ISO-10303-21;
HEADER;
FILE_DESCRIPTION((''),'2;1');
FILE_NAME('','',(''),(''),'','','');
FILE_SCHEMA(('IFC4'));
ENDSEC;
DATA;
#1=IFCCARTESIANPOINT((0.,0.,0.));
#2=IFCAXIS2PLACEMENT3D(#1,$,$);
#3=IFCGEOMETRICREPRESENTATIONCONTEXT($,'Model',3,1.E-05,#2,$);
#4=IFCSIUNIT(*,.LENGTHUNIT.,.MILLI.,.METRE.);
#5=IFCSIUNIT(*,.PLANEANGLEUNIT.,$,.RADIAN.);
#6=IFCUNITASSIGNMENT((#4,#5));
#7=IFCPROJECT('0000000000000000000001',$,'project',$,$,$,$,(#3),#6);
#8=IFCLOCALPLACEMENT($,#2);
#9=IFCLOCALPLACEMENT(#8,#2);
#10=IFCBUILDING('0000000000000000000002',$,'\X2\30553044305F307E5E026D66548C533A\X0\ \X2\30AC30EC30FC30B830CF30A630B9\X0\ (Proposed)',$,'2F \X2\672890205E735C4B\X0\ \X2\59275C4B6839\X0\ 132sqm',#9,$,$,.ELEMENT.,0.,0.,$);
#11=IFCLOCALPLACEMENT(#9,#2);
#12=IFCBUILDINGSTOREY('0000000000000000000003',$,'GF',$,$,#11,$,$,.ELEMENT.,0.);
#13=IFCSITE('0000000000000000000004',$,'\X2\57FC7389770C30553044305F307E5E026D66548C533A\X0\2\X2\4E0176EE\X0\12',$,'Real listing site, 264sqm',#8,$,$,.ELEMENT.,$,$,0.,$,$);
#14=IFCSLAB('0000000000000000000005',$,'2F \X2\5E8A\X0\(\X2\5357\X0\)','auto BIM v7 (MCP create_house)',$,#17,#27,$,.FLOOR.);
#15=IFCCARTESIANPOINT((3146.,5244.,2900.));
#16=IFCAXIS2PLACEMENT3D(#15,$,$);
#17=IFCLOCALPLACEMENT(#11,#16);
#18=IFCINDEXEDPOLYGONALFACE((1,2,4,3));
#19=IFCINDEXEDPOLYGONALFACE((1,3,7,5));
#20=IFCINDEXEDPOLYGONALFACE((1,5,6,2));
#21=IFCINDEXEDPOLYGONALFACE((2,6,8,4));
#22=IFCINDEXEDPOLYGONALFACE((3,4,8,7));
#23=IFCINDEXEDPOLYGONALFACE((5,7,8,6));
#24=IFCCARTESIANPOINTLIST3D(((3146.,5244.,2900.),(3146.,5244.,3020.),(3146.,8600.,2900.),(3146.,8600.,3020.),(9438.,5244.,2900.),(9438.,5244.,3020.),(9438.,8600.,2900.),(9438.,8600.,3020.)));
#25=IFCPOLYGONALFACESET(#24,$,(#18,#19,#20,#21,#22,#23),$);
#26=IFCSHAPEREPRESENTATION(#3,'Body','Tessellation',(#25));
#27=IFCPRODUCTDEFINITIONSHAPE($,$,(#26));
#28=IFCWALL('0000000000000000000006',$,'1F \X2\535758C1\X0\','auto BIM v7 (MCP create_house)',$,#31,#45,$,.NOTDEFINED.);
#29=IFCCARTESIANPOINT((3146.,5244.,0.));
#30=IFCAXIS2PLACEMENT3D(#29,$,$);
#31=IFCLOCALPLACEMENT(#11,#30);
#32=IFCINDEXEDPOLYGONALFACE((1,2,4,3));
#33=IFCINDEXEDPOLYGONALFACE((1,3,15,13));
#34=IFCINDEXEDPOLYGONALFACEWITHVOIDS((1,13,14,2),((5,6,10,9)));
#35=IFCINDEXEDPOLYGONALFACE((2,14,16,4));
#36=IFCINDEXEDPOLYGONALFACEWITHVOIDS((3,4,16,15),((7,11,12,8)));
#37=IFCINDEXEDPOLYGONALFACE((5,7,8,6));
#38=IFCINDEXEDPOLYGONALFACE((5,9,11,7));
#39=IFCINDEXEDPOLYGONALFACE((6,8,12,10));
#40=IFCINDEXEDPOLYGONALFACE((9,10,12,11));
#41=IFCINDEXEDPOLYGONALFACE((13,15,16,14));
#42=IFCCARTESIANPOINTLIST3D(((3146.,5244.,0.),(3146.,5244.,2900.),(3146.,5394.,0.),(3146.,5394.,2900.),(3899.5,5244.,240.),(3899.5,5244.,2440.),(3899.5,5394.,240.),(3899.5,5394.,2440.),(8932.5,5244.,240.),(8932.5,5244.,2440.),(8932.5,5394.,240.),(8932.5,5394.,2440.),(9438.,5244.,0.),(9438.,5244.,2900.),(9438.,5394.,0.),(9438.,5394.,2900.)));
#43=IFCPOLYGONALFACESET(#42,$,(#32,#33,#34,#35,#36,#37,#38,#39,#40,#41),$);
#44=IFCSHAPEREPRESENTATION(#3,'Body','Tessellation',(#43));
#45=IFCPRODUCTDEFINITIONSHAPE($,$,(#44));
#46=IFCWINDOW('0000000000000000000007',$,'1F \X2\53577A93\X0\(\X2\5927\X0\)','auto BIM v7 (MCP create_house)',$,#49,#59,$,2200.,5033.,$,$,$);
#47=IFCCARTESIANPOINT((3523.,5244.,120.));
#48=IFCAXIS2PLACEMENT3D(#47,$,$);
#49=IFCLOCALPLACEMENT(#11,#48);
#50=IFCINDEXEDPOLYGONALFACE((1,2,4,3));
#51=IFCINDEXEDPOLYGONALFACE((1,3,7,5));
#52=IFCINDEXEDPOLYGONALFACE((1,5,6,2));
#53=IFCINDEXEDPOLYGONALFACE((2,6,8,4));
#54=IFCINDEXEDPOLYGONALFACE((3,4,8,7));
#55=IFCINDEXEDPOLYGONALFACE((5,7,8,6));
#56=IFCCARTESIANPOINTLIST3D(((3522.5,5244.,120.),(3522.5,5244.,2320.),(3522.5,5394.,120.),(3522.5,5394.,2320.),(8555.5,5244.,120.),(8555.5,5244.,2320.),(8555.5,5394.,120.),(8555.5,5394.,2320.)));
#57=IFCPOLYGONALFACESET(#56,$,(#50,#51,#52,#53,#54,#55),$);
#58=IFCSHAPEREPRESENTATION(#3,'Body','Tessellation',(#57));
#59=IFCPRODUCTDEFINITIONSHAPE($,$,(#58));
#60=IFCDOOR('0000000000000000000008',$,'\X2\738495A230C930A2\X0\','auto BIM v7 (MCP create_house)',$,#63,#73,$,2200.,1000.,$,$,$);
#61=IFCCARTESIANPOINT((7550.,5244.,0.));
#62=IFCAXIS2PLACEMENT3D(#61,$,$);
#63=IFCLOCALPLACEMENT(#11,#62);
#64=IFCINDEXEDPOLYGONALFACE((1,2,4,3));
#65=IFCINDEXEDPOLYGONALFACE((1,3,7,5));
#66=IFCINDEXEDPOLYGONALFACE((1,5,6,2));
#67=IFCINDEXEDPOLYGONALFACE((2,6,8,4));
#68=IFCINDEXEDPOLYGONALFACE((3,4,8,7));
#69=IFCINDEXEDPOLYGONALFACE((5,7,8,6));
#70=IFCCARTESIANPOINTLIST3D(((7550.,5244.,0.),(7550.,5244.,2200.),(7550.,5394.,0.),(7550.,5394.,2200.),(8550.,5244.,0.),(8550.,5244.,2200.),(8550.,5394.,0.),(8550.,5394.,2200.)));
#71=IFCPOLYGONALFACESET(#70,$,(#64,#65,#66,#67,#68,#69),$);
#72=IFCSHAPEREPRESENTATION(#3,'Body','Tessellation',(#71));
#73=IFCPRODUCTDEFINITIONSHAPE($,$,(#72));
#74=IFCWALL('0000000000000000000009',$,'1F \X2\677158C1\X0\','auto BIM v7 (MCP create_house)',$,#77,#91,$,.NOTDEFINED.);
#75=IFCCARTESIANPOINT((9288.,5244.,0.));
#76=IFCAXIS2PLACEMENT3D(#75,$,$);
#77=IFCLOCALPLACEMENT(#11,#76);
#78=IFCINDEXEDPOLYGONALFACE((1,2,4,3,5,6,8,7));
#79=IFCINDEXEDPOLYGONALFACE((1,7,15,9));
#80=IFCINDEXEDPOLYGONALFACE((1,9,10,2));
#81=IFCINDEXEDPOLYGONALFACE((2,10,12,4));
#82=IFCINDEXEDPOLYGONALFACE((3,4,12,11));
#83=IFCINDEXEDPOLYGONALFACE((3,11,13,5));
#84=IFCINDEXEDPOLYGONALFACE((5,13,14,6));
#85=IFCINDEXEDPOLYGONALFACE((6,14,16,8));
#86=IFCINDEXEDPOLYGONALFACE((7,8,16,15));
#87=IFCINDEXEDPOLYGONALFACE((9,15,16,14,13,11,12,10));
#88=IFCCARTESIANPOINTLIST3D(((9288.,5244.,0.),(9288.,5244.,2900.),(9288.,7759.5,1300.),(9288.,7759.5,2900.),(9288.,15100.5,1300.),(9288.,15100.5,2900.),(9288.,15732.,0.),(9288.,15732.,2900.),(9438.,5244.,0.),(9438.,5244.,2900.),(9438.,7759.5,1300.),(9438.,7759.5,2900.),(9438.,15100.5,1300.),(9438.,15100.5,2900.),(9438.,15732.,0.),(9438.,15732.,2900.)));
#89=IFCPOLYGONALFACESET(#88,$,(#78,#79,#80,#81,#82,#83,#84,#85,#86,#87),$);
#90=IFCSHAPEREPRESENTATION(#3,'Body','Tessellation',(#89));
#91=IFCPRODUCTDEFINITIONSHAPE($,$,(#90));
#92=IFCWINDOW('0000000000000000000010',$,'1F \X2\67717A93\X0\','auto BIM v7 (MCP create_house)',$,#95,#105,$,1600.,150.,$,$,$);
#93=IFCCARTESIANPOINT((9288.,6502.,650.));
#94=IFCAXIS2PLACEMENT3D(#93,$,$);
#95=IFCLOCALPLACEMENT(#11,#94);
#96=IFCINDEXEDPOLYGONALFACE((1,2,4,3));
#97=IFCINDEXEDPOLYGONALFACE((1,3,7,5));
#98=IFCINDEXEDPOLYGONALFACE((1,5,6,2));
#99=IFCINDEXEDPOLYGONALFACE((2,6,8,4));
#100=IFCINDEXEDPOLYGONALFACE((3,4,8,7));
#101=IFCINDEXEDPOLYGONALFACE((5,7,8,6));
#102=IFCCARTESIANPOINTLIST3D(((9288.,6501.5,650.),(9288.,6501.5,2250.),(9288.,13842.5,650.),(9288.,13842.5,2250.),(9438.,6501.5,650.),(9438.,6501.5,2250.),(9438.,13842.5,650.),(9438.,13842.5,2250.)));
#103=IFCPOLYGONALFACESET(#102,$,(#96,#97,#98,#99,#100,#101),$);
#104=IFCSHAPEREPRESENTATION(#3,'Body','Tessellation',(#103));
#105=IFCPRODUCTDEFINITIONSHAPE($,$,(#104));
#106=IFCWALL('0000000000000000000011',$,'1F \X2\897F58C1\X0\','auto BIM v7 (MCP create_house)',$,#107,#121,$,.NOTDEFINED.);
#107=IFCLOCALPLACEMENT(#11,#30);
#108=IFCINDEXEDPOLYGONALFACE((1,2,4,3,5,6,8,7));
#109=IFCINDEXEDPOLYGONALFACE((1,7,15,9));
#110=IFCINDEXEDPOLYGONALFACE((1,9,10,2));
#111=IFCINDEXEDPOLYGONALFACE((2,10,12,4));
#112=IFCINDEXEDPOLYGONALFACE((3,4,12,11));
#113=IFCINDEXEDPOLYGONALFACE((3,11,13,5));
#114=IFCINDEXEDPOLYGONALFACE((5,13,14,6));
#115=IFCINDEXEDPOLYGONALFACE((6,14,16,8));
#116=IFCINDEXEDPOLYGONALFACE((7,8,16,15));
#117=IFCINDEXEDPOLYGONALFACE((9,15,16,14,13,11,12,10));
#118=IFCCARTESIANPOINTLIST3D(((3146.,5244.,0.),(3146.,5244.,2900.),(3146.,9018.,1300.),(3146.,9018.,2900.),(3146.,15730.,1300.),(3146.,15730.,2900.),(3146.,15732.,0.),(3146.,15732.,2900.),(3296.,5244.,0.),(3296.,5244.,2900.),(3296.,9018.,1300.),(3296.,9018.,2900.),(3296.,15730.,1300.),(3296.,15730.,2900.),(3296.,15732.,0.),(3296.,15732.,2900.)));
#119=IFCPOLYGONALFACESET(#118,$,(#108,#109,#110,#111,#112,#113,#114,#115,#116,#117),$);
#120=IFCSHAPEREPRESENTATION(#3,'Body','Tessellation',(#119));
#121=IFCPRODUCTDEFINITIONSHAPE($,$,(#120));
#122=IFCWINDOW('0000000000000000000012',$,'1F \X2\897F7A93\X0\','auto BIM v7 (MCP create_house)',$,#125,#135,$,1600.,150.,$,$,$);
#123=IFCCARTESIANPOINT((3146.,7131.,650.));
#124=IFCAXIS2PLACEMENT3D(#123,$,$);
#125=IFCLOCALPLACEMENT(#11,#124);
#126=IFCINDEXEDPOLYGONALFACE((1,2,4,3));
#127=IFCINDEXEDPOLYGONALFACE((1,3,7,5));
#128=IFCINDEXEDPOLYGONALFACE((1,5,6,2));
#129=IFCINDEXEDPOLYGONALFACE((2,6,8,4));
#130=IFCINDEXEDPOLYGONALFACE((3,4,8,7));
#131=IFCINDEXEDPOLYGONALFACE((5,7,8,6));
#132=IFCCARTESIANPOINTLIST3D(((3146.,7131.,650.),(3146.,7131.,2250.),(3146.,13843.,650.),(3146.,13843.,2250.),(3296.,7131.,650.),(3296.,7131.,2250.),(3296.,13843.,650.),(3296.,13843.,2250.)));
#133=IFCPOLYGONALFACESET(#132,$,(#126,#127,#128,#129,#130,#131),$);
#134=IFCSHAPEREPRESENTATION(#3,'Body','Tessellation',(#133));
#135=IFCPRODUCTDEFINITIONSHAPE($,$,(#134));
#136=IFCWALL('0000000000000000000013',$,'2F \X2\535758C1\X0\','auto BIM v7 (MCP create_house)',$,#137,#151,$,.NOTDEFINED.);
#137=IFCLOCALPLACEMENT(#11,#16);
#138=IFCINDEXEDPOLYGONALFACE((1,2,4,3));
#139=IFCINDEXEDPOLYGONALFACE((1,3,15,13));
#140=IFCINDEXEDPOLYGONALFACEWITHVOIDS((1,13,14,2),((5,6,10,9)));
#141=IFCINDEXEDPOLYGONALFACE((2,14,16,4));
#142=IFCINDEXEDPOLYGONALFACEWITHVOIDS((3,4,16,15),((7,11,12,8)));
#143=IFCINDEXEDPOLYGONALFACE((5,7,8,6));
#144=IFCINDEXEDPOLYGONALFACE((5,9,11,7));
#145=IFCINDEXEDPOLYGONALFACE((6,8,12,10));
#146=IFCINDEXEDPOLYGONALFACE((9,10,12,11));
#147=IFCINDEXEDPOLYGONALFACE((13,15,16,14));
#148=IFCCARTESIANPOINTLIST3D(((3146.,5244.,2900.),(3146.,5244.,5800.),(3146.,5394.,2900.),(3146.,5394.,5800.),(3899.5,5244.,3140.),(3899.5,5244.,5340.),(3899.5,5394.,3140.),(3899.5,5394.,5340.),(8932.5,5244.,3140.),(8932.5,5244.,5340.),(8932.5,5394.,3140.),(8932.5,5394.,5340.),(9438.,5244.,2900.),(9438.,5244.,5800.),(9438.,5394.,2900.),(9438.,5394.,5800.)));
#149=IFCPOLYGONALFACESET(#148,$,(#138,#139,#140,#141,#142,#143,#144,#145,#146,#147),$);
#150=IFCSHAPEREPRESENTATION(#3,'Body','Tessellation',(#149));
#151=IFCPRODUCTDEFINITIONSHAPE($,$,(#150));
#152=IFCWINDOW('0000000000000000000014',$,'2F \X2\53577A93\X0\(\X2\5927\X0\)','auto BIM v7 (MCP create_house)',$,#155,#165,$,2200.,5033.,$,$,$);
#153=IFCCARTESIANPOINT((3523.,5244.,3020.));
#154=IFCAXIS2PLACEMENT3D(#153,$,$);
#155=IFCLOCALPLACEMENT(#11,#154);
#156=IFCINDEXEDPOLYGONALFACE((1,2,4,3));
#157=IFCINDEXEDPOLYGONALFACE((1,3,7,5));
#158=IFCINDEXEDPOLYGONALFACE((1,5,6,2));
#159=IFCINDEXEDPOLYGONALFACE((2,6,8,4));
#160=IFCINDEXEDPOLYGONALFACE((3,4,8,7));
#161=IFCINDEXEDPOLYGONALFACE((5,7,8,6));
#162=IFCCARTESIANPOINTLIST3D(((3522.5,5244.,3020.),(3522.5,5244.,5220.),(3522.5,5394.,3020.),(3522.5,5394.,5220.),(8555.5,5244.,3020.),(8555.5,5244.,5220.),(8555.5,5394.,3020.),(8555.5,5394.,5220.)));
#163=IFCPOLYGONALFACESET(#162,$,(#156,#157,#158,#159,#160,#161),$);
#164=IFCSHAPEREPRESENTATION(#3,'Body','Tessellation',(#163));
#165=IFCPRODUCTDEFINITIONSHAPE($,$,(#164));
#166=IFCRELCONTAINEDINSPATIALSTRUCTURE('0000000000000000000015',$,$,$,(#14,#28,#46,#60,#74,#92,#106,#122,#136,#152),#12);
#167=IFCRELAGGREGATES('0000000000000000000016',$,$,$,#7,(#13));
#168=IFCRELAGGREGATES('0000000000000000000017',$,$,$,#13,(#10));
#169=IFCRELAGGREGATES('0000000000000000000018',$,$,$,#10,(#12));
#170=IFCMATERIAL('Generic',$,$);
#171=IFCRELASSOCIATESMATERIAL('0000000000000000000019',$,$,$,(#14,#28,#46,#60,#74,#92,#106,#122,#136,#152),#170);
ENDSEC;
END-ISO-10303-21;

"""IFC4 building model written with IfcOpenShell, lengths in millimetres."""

from ifc_helpers import new_model, si_unit, frame, frame_2d, origin, place, context, project, spatial, rectangle, extrude, material, element, fill, save


model = new_model("IFC4")

# Units and contexts
model_context = context("Model", 3, precision=1e-05, world=origin())
ifc_project = project(units=[si_unit("LENGTHUNIT", "METRE", prefix="MILLI"), si_unit("PLANEANGLEUNIT", "RADIAN")], contexts=[model_context])

# Site, building, storey
site_placement = place(None, origin())
site = spatial("IfcSite", under=ifc_project, at=site_placement, Name="埼玉県さいたま市浦和区2丁目12", ObjectType="Real listing site, 264sqm", CompositionType="ELEMENT", RefElevation=0.0)
building_placement = place(site_placement, origin())
building = spatial("IfcBuilding", under=site, at=building_placement, Name="さいたま市浦和区 ガレージハウス (Proposed)", ObjectType="2F 木造平屋 大屋根 132sqm", CompositionType="ELEMENT", ElevationOfRefHeight=0.0, ElevationOfTerrain=0.0)
storey_placement = place(building_placement, origin())
storey = spatial("IfcBuildingStorey", under=building, at=storey_placement, Name="GF", CompositionType="ELEMENT", Elevation=0.0)

# Slab
ifc_material = material(Name="Generic")
slab_1_placement = place(storey_placement, frame((3146.0, 5244.0, 2900.0)))
element("IfcSlab", 1, at=slab_1_placement, inside=storey, material=ifc_material, Name="2F 床(南)", Description="auto BIM v7 (MCP create_house)", PredefinedType="FLOOR", context=model_context, shape_type="SweptSolid", body=[
    extrude(rectangle(XDim=6292.0, YDim=3356.0, at=frame_2d((3146.0, 1678.0))), frame((3146.0, 5244.0, 2900.0)), (0.0, 0.0, 1.0), 120.0),
])

# Wall, openings, window, door
wall_1_placement = place(storey_placement, frame((3146.0, 5244.0, 0.0)))
wall_1 = element("IfcWall", 2, at=wall_1_placement, inside=storey, material=ifc_material, Name="1F 南壁", Description="auto BIM v7 (MCP create_house)", PredefinedType="NOTDEFINED", context=model_context, shape_type="SweptSolid", body=[
    extrude(rectangle(XDim=6292.0, YDim=150.0, at=frame_2d((3146.0, 75.0))), frame((3146.0, 5244.0, 0.0)), (0.0, 0.0, 1.0), 2900.0),
])
opening_1_placement = place(storey_placement, frame((3523.0, 5244.0, 120.0)))
opening_1 = element("IfcOpeningElement", 3, at=opening_1_placement, cuts=wall_1, PredefinedType="NOTDEFINED", context=model_context, shape_type="SweptSolid", body=[
    extrude(rectangle(XDim=5033.0, YDim=150.0, at=frame_2d((2516.0, 75.0))), frame((3523.0, 5244.0, 120.0)), (0.0, 0.0, 1.0), 2200.0),
])
opening_2_placement = place(storey_placement, frame((7550.0, 5244.0, 0.0)))
opening_2 = element("IfcOpeningElement", 4, at=opening_2_placement, cuts=wall_1, PredefinedType="NOTDEFINED", context=model_context, shape_type="SweptSolid", body=[
    extrude(rectangle(XDim=1000.0, YDim=150.0, at=frame_2d((500.0, 75.0))), frame((7550.0, 5244.0, 0.0)), (0.0, 0.0, 1.0), 2200.0),
])
window_1_placement = place(storey_placement, frame((3523.0, 5244.0, 120.0)))
window_1 = element("IfcWindow", 5, at=window_1_placement, inside=storey, material=ifc_material, Name="1F 南窓(大)", Description="auto BIM v7 (MCP create_house)", OverallHeight=2200.0, OverallWidth=5033.0, context=model_context, shape_type="SweptSolid", body=[
    extrude(rectangle(XDim=5033.0, YDim=150.0, at=frame_2d((2516.0, 75.0))), frame((3523.0, 5244.0, 120.0)), (0.0, 0.0, 1.0), 2200.0),
])
fill(opening_1, window_1)
door_placement = place(storey_placement, frame((7550.0, 5244.0, 0.0)))
door = element("IfcDoor", 6, at=door_placement, inside=storey, material=ifc_material, Name="玄関ドア", Description="auto BIM v7 (MCP create_house)", OverallHeight=2200.0, OverallWidth=1000.0, context=model_context, shape_type="SweptSolid", body=[
    extrude(rectangle(XDim=1000.0, YDim=150.0, at=frame_2d((500.0, 75.0))), frame((7550.0, 5244.0, 0.0)), (0.0, 0.0, 1.0), 2200.0),
])
fill(opening_2, door)

# Walls, openings, windows
wall_2_placement = place(storey_placement, frame((9288.0, 5244.0, 0.0)))
wall_2 = element("IfcWall", 7, at=wall_2_placement, inside=storey, material=ifc_material, Name="1F 東壁", Description="auto BIM v7 (MCP create_house)", PredefinedType="NOTDEFINED", context=model_context, shape_type="SweptSolid", body=[
    extrude(rectangle(XDim=150.0, YDim=10488.0, at=frame_2d((75.0, 5244.0))), frame((9288.0, 5244.0, 0.0)), (0.0, 0.0, 1.0), 2900.0),
])
opening_3_placement = place(storey_placement, frame((9288.0, 6502.0, 650.0)))
opening_3 = element("IfcOpeningElement", 8, at=opening_3_placement, cuts=wall_2, PredefinedType="NOTDEFINED", context=model_context, shape_type="SweptSolid", body=[
    extrude(rectangle(XDim=150.0, YDim=7341.0, at=frame_2d((75.0, 3670.0))), frame((9288.0, 6502.0, 650.0)), (0.0, 0.0, 1.0), 1600.0),
])
window_2_placement = place(storey_placement, frame((9288.0, 6502.0, 650.0)))
window_2 = element("IfcWindow", 9, at=window_2_placement, inside=storey, material=ifc_material, Name="1F 東窓", Description="auto BIM v7 (MCP create_house)", OverallHeight=1600.0, OverallWidth=150.0, context=model_context, shape_type="SweptSolid", body=[
    extrude(rectangle(XDim=150.0, YDim=7341.0, at=frame_2d((75.0, 3670.0))), frame((9288.0, 6502.0, 650.0)), (0.0, 0.0, 1.0), 1600.0),
])
fill(opening_3, window_2)
wall_3_placement = place(storey_placement, frame((3146.0, 5244.0, 0.0)))
wall_3 = element("IfcWall", 10, at=wall_3_placement, inside=storey, material=ifc_material, Name="1F 西壁", Description="auto BIM v7 (MCP create_house)", PredefinedType="NOTDEFINED", context=model_context, shape_type="SweptSolid", body=[
    extrude(rectangle(XDim=150.0, YDim=10488.0, at=frame_2d((75.0, 5244.0))), frame((3146.0, 5244.0, 0.0)), (0.0, 0.0, 1.0), 2900.0),
])
opening_4_placement = place(storey_placement, frame((3146.0, 7131.0, 650.0)))
opening_4 = element("IfcOpeningElement", 11, at=opening_4_placement, cuts=wall_3, PredefinedType="NOTDEFINED", context=model_context, shape_type="SweptSolid", body=[
    extrude(rectangle(XDim=150.0, YDim=6712.0, at=frame_2d((75.0, 3356.0))), frame((3146.0, 7131.0, 650.0)), (0.0, 0.0, 1.0), 1600.0),
])
window_3_placement = place(storey_placement, frame((3146.0, 7131.0, 650.0)))
window_3 = element("IfcWindow", 12, at=window_3_placement, inside=storey, material=ifc_material, Name="1F 西窓", Description="auto BIM v7 (MCP create_house)", OverallHeight=1600.0, OverallWidth=150.0, context=model_context, shape_type="SweptSolid", body=[
    extrude(rectangle(XDim=150.0, YDim=6712.0, at=frame_2d((75.0, 3356.0))), frame((3146.0, 7131.0, 650.0)), (0.0, 0.0, 1.0), 1600.0),
])
fill(opening_4, window_3)

# Wall, opening, window
wall_4_placement = place(storey_placement, frame((3146.0, 5244.0, 2900.0)))
wall_4 = element("IfcWall", 13, at=wall_4_placement, inside=storey, material=ifc_material, Name="2F 南壁", Description="auto BIM v7 (MCP create_house)", PredefinedType="NOTDEFINED", context=model_context, shape_type="SweptSolid", body=[
    extrude(rectangle(XDim=6292.0, YDim=150.0, at=frame_2d((3146.0, 75.0))), frame((3146.0, 5244.0, 2900.0)), (0.0, 0.0, 1.0), 2900.0),
])
opening_5_placement = place(storey_placement, frame((3523.0, 5244.0, 3020.0)))
opening_5 = element("IfcOpeningElement", 14, at=opening_5_placement, cuts=wall_4, PredefinedType="NOTDEFINED", context=model_context, shape_type="SweptSolid", body=[
    extrude(rectangle(XDim=5033.0, YDim=150.0, at=frame_2d((2516.0, 75.0))), frame((3523.0, 5244.0, 3020.0)), (0.0, 0.0, 1.0), 2200.0),
])
window_4_placement = place(storey_placement, frame((3523.0, 5244.0, 3020.0)))
window_4 = element("IfcWindow", 15, at=window_4_placement, inside=storey, material=ifc_material, Name="2F 南窓(大)", Description="auto BIM v7 (MCP create_house)", OverallHeight=2200.0, OverallWidth=5033.0, context=model_context, shape_type="SweptSolid", body=[
    extrude(rectangle(XDim=5033.0, YDim=150.0, at=frame_2d((2516.0, 75.0))), frame((3523.0, 5244.0, 3020.0)), (0.0, 0.0, 1.0), 2200.0),
])
fill(opening_5, window_4)

save(model, "model.ifc")
